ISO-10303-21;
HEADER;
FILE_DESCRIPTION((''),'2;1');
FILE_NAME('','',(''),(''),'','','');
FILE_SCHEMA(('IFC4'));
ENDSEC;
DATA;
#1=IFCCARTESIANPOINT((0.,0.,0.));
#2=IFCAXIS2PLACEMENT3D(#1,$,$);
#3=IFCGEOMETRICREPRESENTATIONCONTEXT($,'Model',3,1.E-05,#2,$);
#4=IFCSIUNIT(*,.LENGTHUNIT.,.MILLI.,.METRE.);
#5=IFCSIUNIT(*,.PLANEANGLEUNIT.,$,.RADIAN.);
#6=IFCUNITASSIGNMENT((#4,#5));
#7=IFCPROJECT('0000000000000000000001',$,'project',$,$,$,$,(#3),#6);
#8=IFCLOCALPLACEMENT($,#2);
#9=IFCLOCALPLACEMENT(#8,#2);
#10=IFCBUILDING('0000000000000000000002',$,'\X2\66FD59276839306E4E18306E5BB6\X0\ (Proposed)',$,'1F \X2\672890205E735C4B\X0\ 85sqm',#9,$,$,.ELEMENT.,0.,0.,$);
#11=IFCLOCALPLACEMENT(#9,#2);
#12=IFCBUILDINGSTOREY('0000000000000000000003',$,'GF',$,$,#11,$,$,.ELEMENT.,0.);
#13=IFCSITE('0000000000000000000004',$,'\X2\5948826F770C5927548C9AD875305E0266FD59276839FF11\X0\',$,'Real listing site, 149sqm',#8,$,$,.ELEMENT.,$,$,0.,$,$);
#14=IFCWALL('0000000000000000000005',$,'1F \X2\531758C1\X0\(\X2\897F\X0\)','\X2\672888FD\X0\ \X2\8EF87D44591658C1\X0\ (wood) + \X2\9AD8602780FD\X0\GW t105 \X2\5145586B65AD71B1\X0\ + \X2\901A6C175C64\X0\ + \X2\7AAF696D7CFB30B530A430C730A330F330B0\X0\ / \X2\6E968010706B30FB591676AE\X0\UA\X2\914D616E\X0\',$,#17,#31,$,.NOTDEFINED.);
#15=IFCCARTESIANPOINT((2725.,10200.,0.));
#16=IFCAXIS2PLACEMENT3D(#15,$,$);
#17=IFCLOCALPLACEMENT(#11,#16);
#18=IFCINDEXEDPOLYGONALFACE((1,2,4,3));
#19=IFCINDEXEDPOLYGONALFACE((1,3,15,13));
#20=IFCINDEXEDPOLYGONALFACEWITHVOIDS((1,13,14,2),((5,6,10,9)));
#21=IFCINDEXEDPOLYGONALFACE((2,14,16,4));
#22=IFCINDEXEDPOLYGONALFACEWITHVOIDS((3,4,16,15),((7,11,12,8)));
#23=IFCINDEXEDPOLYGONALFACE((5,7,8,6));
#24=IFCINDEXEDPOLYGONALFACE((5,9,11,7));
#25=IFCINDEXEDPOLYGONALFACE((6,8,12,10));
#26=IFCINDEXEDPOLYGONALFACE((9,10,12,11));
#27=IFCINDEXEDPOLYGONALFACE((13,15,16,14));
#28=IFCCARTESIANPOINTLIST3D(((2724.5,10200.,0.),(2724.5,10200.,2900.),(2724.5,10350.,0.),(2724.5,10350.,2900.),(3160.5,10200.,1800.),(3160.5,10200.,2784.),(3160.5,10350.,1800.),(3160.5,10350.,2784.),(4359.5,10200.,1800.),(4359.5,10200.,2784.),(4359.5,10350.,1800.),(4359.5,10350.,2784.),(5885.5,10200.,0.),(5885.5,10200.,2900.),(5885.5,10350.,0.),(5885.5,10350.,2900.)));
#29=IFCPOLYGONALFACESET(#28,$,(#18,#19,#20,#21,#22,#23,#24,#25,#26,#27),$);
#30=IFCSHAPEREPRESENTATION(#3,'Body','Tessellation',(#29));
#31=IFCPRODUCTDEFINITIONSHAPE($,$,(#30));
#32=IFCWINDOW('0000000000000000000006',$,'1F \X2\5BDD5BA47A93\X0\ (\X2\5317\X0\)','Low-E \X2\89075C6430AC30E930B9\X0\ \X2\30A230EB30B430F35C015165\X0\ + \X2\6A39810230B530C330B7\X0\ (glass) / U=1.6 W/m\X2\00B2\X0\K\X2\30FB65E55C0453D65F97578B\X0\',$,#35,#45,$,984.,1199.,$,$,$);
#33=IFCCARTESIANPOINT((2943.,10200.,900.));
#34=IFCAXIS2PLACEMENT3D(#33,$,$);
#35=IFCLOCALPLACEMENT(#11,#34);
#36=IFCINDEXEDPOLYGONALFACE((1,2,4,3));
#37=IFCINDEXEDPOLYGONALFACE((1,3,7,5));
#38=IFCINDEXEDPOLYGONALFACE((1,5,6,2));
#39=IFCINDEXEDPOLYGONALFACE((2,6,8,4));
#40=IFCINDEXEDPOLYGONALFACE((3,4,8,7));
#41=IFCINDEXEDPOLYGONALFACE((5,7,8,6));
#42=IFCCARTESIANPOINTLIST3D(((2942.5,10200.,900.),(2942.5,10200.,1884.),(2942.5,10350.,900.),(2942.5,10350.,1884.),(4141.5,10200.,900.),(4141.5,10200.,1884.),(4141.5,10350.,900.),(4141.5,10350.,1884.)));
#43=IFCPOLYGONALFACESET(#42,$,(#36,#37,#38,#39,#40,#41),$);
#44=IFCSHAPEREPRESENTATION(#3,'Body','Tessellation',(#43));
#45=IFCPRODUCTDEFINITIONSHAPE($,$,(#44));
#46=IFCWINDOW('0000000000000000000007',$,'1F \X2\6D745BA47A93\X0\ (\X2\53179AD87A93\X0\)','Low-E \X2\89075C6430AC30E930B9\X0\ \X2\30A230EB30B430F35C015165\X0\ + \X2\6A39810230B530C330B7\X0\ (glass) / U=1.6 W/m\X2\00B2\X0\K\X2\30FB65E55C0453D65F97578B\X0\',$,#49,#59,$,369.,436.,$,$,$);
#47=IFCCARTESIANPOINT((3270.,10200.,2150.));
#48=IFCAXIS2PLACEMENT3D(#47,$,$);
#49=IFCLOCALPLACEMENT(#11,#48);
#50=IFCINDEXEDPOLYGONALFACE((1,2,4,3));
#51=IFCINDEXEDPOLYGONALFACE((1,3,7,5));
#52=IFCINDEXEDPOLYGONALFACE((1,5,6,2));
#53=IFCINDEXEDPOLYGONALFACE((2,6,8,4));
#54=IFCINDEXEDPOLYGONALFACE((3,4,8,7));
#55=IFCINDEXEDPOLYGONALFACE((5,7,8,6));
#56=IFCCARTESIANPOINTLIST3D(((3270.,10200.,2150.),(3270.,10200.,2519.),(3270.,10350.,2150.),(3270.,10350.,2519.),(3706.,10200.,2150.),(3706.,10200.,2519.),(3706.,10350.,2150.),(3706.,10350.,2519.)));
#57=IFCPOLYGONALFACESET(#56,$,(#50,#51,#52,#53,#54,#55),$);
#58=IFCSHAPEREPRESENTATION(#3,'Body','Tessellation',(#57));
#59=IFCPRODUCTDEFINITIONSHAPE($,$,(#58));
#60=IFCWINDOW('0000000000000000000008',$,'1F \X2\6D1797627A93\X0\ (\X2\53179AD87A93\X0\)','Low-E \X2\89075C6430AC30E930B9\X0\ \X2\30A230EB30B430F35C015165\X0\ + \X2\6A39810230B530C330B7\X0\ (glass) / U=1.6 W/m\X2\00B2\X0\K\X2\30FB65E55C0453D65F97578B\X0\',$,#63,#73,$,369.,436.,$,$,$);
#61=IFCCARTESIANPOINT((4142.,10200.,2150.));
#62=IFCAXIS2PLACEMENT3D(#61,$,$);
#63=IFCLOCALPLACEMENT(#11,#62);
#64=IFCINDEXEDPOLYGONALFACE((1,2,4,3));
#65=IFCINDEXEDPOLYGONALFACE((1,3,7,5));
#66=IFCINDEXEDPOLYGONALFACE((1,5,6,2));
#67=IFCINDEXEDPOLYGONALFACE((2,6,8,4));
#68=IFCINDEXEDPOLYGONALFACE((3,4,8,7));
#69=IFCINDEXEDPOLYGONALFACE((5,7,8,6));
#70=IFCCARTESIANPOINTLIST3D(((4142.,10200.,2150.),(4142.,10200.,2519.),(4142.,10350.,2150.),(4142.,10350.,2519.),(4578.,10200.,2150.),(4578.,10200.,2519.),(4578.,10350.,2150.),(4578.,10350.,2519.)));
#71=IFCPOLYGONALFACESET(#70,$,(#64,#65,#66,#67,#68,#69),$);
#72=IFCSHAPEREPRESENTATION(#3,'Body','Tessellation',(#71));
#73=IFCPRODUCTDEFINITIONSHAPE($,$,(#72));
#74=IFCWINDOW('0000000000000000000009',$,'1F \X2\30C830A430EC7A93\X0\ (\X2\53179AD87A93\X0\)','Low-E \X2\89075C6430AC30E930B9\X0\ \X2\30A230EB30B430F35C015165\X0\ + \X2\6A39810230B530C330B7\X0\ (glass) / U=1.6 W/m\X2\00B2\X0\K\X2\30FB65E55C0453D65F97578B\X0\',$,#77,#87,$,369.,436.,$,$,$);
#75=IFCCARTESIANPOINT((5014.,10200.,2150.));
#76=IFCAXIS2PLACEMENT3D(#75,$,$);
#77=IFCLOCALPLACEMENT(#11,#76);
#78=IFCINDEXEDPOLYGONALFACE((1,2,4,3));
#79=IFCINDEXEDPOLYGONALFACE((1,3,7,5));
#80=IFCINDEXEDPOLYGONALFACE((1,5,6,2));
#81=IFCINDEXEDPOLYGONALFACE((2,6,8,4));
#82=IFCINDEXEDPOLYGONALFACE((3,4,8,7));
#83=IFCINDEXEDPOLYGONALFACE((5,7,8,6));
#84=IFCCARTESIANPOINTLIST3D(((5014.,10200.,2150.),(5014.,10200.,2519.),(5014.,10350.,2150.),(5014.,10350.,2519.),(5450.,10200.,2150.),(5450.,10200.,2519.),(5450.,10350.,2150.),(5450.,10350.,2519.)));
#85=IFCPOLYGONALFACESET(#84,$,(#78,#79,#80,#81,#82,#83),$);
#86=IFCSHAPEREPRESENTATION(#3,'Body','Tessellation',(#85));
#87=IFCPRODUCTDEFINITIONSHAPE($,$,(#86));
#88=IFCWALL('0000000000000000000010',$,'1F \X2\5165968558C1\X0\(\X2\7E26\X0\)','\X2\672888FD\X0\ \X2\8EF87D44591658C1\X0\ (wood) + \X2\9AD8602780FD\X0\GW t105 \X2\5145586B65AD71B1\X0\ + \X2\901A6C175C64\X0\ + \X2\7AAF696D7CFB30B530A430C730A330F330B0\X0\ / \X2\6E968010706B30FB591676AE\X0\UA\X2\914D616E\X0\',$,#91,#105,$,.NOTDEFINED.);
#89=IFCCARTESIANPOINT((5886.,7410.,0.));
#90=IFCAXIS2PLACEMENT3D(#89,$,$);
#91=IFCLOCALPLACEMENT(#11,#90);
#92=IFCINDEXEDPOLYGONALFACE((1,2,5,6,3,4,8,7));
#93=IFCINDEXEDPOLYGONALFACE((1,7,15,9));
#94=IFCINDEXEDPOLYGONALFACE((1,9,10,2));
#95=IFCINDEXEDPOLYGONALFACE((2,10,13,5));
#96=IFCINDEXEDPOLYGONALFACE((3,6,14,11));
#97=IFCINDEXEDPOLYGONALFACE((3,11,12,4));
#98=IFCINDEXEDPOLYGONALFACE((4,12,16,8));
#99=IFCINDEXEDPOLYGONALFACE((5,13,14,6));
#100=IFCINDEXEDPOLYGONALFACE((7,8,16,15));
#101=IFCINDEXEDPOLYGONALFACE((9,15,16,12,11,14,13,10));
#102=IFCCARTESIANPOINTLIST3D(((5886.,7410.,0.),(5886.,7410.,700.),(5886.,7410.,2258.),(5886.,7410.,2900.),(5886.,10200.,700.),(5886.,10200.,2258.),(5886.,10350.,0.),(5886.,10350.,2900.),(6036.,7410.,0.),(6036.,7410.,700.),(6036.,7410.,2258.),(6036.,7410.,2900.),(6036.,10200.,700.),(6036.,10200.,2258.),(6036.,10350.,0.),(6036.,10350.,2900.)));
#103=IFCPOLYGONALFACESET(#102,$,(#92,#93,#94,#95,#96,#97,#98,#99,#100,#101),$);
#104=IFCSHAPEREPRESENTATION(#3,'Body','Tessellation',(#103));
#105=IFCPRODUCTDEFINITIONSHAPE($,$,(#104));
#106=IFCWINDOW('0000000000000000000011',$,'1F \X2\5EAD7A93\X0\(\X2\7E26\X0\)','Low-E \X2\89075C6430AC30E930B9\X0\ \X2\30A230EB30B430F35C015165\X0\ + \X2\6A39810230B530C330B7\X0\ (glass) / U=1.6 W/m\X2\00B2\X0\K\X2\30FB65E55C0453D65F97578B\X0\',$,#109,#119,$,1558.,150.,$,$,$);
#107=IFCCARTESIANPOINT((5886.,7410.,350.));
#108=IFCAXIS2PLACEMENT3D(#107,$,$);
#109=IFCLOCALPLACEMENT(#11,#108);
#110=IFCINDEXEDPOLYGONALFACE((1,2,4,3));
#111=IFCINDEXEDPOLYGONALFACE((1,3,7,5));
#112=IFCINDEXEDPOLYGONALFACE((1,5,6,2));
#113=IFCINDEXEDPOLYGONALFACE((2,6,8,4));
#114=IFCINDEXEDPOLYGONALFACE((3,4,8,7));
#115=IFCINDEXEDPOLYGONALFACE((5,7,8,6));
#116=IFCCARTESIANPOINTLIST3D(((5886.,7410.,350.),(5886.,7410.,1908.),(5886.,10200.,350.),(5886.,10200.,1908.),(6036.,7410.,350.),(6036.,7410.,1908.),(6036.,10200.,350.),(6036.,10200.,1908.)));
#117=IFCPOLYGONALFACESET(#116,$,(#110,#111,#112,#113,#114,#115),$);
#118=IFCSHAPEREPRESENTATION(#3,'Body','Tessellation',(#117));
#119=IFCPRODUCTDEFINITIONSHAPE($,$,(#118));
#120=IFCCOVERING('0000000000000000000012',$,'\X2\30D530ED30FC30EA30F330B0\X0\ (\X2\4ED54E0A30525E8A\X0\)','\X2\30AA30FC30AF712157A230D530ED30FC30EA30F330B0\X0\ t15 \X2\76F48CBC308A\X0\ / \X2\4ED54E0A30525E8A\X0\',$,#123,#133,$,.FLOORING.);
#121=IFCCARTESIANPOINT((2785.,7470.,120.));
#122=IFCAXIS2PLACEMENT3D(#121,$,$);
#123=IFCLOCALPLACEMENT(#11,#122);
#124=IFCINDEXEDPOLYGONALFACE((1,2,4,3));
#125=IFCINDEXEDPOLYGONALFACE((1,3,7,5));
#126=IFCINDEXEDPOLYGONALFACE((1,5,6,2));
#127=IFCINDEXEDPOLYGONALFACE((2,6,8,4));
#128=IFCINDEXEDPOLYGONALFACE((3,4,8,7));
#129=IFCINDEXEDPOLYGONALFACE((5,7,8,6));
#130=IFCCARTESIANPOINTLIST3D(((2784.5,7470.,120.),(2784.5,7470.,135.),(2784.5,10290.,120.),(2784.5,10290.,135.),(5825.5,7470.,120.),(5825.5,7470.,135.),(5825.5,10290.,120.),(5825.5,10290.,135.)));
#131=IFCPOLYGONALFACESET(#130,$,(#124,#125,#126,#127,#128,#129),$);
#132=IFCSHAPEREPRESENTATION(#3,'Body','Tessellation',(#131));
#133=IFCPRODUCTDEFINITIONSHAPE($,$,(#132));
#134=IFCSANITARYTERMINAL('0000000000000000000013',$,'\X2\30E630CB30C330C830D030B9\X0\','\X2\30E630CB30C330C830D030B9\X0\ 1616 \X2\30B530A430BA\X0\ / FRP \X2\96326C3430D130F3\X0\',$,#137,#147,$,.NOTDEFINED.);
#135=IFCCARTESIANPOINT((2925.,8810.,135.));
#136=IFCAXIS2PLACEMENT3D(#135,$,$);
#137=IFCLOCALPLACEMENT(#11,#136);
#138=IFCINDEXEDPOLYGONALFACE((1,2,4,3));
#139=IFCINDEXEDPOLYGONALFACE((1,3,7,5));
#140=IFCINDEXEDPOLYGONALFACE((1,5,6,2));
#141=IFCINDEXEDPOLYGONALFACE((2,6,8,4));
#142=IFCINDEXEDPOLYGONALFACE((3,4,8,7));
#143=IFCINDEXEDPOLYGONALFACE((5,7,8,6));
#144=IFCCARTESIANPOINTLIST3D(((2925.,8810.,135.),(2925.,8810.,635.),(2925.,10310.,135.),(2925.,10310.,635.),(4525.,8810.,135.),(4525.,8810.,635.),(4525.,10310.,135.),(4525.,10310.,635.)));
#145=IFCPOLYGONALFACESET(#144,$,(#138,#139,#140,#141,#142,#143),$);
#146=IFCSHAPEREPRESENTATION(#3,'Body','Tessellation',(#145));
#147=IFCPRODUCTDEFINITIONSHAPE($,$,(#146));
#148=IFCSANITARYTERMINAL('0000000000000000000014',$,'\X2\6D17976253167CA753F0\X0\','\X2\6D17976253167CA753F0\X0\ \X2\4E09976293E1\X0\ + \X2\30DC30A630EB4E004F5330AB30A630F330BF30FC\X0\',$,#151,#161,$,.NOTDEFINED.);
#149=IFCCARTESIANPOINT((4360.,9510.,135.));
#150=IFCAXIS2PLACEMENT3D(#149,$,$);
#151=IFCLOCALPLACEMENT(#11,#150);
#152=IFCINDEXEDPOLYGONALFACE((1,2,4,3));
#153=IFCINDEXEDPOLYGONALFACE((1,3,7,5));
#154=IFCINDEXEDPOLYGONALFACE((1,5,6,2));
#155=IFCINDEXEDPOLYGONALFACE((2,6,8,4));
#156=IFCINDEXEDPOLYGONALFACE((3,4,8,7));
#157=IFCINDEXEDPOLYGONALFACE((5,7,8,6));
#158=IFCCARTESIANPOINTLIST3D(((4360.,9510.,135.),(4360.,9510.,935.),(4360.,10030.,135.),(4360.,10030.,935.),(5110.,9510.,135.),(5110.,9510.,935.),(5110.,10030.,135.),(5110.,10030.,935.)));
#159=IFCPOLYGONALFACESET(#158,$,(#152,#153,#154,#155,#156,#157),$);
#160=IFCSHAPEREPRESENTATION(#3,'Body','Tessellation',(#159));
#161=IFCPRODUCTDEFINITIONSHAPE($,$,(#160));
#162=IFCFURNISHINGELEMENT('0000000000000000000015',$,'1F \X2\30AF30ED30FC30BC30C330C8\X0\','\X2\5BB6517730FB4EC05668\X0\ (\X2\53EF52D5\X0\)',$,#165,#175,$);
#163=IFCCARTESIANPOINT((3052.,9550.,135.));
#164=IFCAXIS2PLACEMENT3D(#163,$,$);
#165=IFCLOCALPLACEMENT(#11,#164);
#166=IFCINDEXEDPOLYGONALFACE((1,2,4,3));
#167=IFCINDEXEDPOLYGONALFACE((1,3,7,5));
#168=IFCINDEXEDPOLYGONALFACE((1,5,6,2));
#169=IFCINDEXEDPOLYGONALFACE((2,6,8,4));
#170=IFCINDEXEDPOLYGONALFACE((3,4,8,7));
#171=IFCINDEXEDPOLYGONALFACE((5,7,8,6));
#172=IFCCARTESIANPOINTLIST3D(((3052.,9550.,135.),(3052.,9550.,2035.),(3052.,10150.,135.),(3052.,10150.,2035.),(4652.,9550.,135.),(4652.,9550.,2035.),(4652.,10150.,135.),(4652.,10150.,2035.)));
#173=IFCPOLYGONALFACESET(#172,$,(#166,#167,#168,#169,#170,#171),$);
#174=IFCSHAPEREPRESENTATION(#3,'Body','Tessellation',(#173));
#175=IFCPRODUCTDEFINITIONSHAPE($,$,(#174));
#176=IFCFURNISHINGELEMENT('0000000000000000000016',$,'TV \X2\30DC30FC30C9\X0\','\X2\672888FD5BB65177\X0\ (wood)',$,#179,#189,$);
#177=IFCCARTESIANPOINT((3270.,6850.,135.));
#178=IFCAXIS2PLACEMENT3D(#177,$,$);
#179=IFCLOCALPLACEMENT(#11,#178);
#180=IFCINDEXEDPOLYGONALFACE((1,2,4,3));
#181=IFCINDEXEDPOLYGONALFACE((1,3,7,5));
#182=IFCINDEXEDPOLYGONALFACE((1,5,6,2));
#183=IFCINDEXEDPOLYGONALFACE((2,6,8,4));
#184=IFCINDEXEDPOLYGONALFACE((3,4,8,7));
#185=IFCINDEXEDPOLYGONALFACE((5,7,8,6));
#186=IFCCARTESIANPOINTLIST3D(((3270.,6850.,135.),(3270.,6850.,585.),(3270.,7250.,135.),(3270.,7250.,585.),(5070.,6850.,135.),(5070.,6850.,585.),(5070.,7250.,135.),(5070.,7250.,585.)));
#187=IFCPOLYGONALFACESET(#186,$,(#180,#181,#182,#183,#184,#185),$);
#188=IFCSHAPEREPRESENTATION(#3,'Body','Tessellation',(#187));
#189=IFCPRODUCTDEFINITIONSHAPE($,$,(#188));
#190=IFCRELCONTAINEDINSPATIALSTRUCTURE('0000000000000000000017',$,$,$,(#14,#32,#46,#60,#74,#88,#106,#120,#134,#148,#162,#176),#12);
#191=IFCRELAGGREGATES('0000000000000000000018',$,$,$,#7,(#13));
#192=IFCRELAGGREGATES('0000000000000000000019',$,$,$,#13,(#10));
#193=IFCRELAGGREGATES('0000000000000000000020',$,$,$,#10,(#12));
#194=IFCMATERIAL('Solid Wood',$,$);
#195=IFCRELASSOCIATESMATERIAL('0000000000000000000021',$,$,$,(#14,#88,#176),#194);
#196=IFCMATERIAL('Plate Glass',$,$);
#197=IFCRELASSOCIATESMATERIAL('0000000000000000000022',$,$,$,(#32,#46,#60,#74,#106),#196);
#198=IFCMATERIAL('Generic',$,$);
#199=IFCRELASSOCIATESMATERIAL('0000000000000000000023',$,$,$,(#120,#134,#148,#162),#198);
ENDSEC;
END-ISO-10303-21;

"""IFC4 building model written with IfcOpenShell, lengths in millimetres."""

from ifc_helpers import new_model, si_unit, frame, frame_2d, origin, place, context, project, spatial, rectangle, extrude, material, element, fill, save


model = new_model("IFC4")

# Units and contexts
model_context = context("Model", 3, precision=1e-05, world=origin())
ifc_project = project(units=[si_unit("LENGTHUNIT", "METRE", prefix="MILLI"), si_unit("PLANEANGLEUNIT", "RADIAN")], contexts=[model_context])

# Site, building, storey
site_placement = place(None, origin())
site = spatial("IfcSite", under=ifc_project, at=site_placement, Name="奈良県大和高田市曽大根１", ObjectType="Real listing site, 149sqm", CompositionType="ELEMENT", RefElevation=0.0)
building_placement = place(site_placement, origin())
building = spatial("IfcBuilding", under=site, at=building_placement, Name="曽大根の丘の家 (Proposed)", ObjectType="1F 木造平屋 85sqm", CompositionType="ELEMENT", ElevationOfRefHeight=0.0, ElevationOfTerrain=0.0)
storey_placement = place(building_placement, origin())
storey = spatial("IfcBuildingStorey", under=building, at=storey_placement, Name="GF", CompositionType="ELEMENT", Elevation=0.0)

# Shared definitions
ifc_material_1 = material(Name="Solid Wood")

# Wall, openings, windows
wall_1_placement = place(storey_placement, frame((2725.0, 10200.0, 0.0)))
wall_1 = element("IfcWall", 1, at=wall_1_placement, inside=storey, material=ifc_material_1, Name="1F 北壁(西)", Description="木製 軸組外壁 (wood) + 高性能GW t105 充填断熱 + 通気層 + 窯業系サイディング / 準耐火・外皮UA配慮", PredefinedType="NOTDEFINED", context=model_context, shape_type="SweptSolid", body=[
    extrude(rectangle(XDim=3161.0, YDim=150.0, at=frame_2d((1580.0, 75.0))), frame((2725.0, 10200.0, 0.0)), (0.0, 0.0, 1.0), 2900.0),
])
opening_1_placement = place(storey_placement, frame((2943.0, 10200.0, 900.0)))
opening_1 = element("IfcOpeningElement", 2, at=opening_1_placement, cuts=wall_1, PredefinedType="NOTDEFINED", context=model_context, shape_type="SweptSolid", body=[
    extrude(rectangle(XDim=1199.0, YDim=150.0, at=frame_2d((599.0, 75.0))), frame((2943.0, 10200.0, 900.0)), (0.0, 0.0, 1.0), 984.0),
])
opening_2_placement = place(storey_placement, frame((3270.0, 10200.0, 2150.0)))
opening_2 = element("IfcOpeningElement", 3, at=opening_2_placement, cuts=wall_1, PredefinedType="NOTDEFINED", context=model_context, shape_type="SweptSolid", body=[
    extrude(rectangle(XDim=436.0, YDim=150.0, at=frame_2d((218.0, 75.0))), frame((3270.0, 10200.0, 2150.0)), (0.0, 0.0, 1.0), 369.0),
])
opening_3_placement = place(storey_placement, frame((4142.0, 10200.0, 2150.0)))
opening_3 = element("IfcOpeningElement", 4, at=opening_3_placement, cuts=wall_1, PredefinedType="NOTDEFINED", context=model_context, shape_type="SweptSolid", body=[
    extrude(rectangle(XDim=436.0, YDim=150.0, at=frame_2d((218.0, 75.0))), frame((4142.0, 10200.0, 2150.0)), (0.0, 0.0, 1.0), 369.0),
])
opening_4_placement = place(storey_placement, frame((5014.0, 10200.0, 2150.0)))
opening_4 = element("IfcOpeningElement", 5, at=opening_4_placement, cuts=wall_1, PredefinedType="NOTDEFINED", context=model_context, shape_type="SweptSolid", body=[
    extrude(rectangle(XDim=436.0, YDim=150.0, at=frame_2d((218.0, 75.0))), frame((5014.0, 10200.0, 2150.0)), (0.0, 0.0, 1.0), 369.0),
])
ifc_material_2 = material(Name="Plate Glass")
window_1_placement = place(storey_placement, frame((2943.0, 10200.0, 900.0)))
window_1 = element("IfcWindow", 6, at=window_1_placement, inside=storey, material=ifc_material_2, Name="1F 寝室窓 (北)", Description="Low-E 複層ガラス アルゴン封入 + 樹脂サッシ (glass) / U=1.6 W/m²K・日射取得型", OverallHeight=984.0, OverallWidth=1199.0, context=model_context, shape_type="SweptSolid", body=[
    extrude(rectangle(XDim=1199.0, YDim=150.0, at=frame_2d((599.0, 75.0))), frame((2943.0, 10200.0, 900.0)), (0.0, 0.0, 1.0), 984.0),
])
fill(opening_1, window_1)
window_2_placement = place(storey_placement, frame((3270.0, 10200.0, 2150.0)))
window_2 = element("IfcWindow", 7, at=window_2_placement, inside=storey, material=ifc_material_2, Name="1F 浴室窓 (北高窓)", Description="Low-E 複層ガラス アルゴン封入 + 樹脂サッシ (glass) / U=1.6 W/m²K・日射取得型", OverallHeight=369.0, OverallWidth=436.0, context=model_context, shape_type="SweptSolid", body=[
    extrude(rectangle(XDim=436.0, YDim=150.0, at=frame_2d((218.0, 75.0))), frame((3270.0, 10200.0, 2150.0)), (0.0, 0.0, 1.0), 369.0),
])
fill(opening_2, window_2)
window_3_placement = place(storey_placement, frame((4142.0, 10200.0, 2150.0)))
window_3 = element("IfcWindow", 8, at=window_3_placement, inside=storey, material=ifc_material_2, Name="1F 洗面窓 (北高窓)", Description="Low-E 複層ガラス アルゴン封入 + 樹脂サッシ (glass) / U=1.6 W/m²K・日射取得型", OverallHeight=369.0, OverallWidth=436.0, context=model_context, shape_type="SweptSolid", body=[
    extrude(rectangle(XDim=436.0, YDim=150.0, at=frame_2d((218.0, 75.0))), frame((4142.0, 10200.0, 2150.0)), (0.0, 0.0, 1.0), 369.0),
])
fill(opening_3, window_3)
window_4_placement = place(storey_placement, frame((5014.0, 10200.0, 2150.0)))
window_4 = element("IfcWindow", 9, at=window_4_placement, inside=storey, material=ifc_material_2, Name="1F トイレ窓 (北高窓)", Description="Low-E 複層ガラス アルゴン封入 + 樹脂サッシ (glass) / U=1.6 W/m²K・日射取得型", OverallHeight=369.0, OverallWidth=436.0, context=model_context, shape_type="SweptSolid", body=[
    extrude(rectangle(XDim=436.0, YDim=150.0, at=frame_2d((218.0, 75.0))), frame((5014.0, 10200.0, 2150.0)), (0.0, 0.0, 1.0), 369.0),
])
fill(opening_4, window_4)

# Wall, opening, window
wall_2_placement = place(storey_placement, frame((5886.0, 7410.0, 0.0)))
wall_2 = element("IfcWall", 10, at=wall_2_placement, inside=storey, material=ifc_material_1, Name="1F 入隅壁(縦)", Description="木製 軸組外壁 (wood) + 高性能GW t105 充填断熱 + 通気層 + 窯業系サイディング / 準耐火・外皮UA配慮", PredefinedType="NOTDEFINED", context=model_context, shape_type="SweptSolid", body=[
    extrude(rectangle(XDim=150.0, YDim=2940.0, at=frame_2d((75.0, 1470.0))), frame((5886.0, 7410.0, 0.0)), (0.0, 0.0, 1.0), 2900.0),
])
opening_5_placement = place(storey_placement, frame((5886.0, 7410.0, 350.0)))
opening_5 = element("IfcOpeningElement", 11, at=opening_5_placement, cuts=wall_2, PredefinedType="NOTDEFINED", context=model_context, shape_type="SweptSolid", body=[
    extrude(rectangle(XDim=150.0, YDim=2790.0, at=frame_2d((75.0, 1395.0))), frame((5886.0, 7410.0, 350.0)), (0.0, 0.0, 1.0), 1558.0),
])
window_5_placement = place(storey_placement, frame((5886.0, 7410.0, 350.0)))
window_5 = element("IfcWindow", 12, at=window_5_placement, inside=storey, material=ifc_material_2, Name="1F 庭窓(縦)", Description="Low-E 複層ガラス アルゴン封入 + 樹脂サッシ (glass) / U=1.6 W/m²K・日射取得型", OverallHeight=1558.0, OverallWidth=150.0, context=model_context, shape_type="SweptSolid", body=[
    extrude(rectangle(XDim=150.0, YDim=2790.0, at=frame_2d((75.0, 1395.0))), frame((5886.0, 7410.0, 350.0)), (0.0, 0.0, 1.0), 1558.0),
])
fill(opening_5, window_5)

# Covering
ifc_material_3 = material(Name="Generic")
covering_placement = place(storey_placement, frame((2785.0, 7470.0, 120.0)))
element("IfcCovering", 13, at=covering_placement, inside=storey, material=ifc_material_3, Name="フローリング (仕上げ床)", Description="オーク無垢フローリング t15 直貼り / 仕上げ床", PredefinedType="FLOORING", context=model_context, shape_type="SweptSolid", body=[
    extrude(rectangle(XDim=3041.0, YDim=2820.0, at=frame_2d((1520.0, 1410.0))), frame((2785.0, 7470.0, 120.0)), (0.0, 0.0, 1.0), 15.0),
])

# Sanitary terminals
sanitary_terminal_1_placement = place(storey_placement, frame((2925.0, 8810.0, 135.0)))
element("IfcSanitaryTerminal", 14, at=sanitary_terminal_1_placement, inside=storey, material=ifc_material_3, Name="ユニットバス", Description="ユニットバス 1616 サイズ / FRP 防水パン", PredefinedType="NOTDEFINED", context=model_context, shape_type="SweptSolid", body=[
    extrude(rectangle(XDim=1600.0, YDim=1500.0, at=frame_2d((800.0, 750.0))), frame((2925.0, 8810.0, 135.0)), (0.0, 0.0, 1.0), 500.0),
])
sanitary_terminal_2_placement = place(storey_placement, frame((4360.0, 9510.0, 135.0)))
element("IfcSanitaryTerminal", 15, at=sanitary_terminal_2_placement, inside=storey, material=ifc_material_3, Name="洗面化粧台", Description="洗面化粧台 三面鏡 + ボウル一体カウンター", PredefinedType="NOTDEFINED", context=model_context, shape_type="SweptSolid", body=[
    extrude(rectangle(XDim=750.0, YDim=520.0, at=frame_2d((375.0, 260.0))), frame((4360.0, 9510.0, 135.0)), (0.0, 0.0, 1.0), 800.0),
])

# Furnishing elements
furnishing_1_placement = place(storey_placement, frame((3052.0, 9550.0, 135.0)))
element("IfcFurnishingElement", 16, at=furnishing_1_placement, inside=storey, material=ifc_material_3, Name="1F クローゼット", Description="家具・什器 (可動)", context=model_context, shape_type="SweptSolid", body=[
    extrude(rectangle(XDim=1600.0, YDim=600.0, at=frame_2d((800.0, 300.0))), frame((3052.0, 9550.0, 135.0)), (0.0, 0.0, 1.0), 1900.0),
])
furnishing_2_placement = place(storey_placement, frame((3270.0, 6850.0, 135.0)))
element("IfcFurnishingElement", 17, at=furnishing_2_placement, inside=storey, material=ifc_material_1, Name="TV ボード", Description="木製家具 (wood)", context=model_context, shape_type="SweptSolid", body=[
    extrude(rectangle(XDim=1800.0, YDim=400.0, at=frame_2d((900.0, 200.0))), frame((3270.0, 6850.0, 135.0)), (0.0, 0.0, 1.0), 450.0),
])

save(model, "model.ifc")
